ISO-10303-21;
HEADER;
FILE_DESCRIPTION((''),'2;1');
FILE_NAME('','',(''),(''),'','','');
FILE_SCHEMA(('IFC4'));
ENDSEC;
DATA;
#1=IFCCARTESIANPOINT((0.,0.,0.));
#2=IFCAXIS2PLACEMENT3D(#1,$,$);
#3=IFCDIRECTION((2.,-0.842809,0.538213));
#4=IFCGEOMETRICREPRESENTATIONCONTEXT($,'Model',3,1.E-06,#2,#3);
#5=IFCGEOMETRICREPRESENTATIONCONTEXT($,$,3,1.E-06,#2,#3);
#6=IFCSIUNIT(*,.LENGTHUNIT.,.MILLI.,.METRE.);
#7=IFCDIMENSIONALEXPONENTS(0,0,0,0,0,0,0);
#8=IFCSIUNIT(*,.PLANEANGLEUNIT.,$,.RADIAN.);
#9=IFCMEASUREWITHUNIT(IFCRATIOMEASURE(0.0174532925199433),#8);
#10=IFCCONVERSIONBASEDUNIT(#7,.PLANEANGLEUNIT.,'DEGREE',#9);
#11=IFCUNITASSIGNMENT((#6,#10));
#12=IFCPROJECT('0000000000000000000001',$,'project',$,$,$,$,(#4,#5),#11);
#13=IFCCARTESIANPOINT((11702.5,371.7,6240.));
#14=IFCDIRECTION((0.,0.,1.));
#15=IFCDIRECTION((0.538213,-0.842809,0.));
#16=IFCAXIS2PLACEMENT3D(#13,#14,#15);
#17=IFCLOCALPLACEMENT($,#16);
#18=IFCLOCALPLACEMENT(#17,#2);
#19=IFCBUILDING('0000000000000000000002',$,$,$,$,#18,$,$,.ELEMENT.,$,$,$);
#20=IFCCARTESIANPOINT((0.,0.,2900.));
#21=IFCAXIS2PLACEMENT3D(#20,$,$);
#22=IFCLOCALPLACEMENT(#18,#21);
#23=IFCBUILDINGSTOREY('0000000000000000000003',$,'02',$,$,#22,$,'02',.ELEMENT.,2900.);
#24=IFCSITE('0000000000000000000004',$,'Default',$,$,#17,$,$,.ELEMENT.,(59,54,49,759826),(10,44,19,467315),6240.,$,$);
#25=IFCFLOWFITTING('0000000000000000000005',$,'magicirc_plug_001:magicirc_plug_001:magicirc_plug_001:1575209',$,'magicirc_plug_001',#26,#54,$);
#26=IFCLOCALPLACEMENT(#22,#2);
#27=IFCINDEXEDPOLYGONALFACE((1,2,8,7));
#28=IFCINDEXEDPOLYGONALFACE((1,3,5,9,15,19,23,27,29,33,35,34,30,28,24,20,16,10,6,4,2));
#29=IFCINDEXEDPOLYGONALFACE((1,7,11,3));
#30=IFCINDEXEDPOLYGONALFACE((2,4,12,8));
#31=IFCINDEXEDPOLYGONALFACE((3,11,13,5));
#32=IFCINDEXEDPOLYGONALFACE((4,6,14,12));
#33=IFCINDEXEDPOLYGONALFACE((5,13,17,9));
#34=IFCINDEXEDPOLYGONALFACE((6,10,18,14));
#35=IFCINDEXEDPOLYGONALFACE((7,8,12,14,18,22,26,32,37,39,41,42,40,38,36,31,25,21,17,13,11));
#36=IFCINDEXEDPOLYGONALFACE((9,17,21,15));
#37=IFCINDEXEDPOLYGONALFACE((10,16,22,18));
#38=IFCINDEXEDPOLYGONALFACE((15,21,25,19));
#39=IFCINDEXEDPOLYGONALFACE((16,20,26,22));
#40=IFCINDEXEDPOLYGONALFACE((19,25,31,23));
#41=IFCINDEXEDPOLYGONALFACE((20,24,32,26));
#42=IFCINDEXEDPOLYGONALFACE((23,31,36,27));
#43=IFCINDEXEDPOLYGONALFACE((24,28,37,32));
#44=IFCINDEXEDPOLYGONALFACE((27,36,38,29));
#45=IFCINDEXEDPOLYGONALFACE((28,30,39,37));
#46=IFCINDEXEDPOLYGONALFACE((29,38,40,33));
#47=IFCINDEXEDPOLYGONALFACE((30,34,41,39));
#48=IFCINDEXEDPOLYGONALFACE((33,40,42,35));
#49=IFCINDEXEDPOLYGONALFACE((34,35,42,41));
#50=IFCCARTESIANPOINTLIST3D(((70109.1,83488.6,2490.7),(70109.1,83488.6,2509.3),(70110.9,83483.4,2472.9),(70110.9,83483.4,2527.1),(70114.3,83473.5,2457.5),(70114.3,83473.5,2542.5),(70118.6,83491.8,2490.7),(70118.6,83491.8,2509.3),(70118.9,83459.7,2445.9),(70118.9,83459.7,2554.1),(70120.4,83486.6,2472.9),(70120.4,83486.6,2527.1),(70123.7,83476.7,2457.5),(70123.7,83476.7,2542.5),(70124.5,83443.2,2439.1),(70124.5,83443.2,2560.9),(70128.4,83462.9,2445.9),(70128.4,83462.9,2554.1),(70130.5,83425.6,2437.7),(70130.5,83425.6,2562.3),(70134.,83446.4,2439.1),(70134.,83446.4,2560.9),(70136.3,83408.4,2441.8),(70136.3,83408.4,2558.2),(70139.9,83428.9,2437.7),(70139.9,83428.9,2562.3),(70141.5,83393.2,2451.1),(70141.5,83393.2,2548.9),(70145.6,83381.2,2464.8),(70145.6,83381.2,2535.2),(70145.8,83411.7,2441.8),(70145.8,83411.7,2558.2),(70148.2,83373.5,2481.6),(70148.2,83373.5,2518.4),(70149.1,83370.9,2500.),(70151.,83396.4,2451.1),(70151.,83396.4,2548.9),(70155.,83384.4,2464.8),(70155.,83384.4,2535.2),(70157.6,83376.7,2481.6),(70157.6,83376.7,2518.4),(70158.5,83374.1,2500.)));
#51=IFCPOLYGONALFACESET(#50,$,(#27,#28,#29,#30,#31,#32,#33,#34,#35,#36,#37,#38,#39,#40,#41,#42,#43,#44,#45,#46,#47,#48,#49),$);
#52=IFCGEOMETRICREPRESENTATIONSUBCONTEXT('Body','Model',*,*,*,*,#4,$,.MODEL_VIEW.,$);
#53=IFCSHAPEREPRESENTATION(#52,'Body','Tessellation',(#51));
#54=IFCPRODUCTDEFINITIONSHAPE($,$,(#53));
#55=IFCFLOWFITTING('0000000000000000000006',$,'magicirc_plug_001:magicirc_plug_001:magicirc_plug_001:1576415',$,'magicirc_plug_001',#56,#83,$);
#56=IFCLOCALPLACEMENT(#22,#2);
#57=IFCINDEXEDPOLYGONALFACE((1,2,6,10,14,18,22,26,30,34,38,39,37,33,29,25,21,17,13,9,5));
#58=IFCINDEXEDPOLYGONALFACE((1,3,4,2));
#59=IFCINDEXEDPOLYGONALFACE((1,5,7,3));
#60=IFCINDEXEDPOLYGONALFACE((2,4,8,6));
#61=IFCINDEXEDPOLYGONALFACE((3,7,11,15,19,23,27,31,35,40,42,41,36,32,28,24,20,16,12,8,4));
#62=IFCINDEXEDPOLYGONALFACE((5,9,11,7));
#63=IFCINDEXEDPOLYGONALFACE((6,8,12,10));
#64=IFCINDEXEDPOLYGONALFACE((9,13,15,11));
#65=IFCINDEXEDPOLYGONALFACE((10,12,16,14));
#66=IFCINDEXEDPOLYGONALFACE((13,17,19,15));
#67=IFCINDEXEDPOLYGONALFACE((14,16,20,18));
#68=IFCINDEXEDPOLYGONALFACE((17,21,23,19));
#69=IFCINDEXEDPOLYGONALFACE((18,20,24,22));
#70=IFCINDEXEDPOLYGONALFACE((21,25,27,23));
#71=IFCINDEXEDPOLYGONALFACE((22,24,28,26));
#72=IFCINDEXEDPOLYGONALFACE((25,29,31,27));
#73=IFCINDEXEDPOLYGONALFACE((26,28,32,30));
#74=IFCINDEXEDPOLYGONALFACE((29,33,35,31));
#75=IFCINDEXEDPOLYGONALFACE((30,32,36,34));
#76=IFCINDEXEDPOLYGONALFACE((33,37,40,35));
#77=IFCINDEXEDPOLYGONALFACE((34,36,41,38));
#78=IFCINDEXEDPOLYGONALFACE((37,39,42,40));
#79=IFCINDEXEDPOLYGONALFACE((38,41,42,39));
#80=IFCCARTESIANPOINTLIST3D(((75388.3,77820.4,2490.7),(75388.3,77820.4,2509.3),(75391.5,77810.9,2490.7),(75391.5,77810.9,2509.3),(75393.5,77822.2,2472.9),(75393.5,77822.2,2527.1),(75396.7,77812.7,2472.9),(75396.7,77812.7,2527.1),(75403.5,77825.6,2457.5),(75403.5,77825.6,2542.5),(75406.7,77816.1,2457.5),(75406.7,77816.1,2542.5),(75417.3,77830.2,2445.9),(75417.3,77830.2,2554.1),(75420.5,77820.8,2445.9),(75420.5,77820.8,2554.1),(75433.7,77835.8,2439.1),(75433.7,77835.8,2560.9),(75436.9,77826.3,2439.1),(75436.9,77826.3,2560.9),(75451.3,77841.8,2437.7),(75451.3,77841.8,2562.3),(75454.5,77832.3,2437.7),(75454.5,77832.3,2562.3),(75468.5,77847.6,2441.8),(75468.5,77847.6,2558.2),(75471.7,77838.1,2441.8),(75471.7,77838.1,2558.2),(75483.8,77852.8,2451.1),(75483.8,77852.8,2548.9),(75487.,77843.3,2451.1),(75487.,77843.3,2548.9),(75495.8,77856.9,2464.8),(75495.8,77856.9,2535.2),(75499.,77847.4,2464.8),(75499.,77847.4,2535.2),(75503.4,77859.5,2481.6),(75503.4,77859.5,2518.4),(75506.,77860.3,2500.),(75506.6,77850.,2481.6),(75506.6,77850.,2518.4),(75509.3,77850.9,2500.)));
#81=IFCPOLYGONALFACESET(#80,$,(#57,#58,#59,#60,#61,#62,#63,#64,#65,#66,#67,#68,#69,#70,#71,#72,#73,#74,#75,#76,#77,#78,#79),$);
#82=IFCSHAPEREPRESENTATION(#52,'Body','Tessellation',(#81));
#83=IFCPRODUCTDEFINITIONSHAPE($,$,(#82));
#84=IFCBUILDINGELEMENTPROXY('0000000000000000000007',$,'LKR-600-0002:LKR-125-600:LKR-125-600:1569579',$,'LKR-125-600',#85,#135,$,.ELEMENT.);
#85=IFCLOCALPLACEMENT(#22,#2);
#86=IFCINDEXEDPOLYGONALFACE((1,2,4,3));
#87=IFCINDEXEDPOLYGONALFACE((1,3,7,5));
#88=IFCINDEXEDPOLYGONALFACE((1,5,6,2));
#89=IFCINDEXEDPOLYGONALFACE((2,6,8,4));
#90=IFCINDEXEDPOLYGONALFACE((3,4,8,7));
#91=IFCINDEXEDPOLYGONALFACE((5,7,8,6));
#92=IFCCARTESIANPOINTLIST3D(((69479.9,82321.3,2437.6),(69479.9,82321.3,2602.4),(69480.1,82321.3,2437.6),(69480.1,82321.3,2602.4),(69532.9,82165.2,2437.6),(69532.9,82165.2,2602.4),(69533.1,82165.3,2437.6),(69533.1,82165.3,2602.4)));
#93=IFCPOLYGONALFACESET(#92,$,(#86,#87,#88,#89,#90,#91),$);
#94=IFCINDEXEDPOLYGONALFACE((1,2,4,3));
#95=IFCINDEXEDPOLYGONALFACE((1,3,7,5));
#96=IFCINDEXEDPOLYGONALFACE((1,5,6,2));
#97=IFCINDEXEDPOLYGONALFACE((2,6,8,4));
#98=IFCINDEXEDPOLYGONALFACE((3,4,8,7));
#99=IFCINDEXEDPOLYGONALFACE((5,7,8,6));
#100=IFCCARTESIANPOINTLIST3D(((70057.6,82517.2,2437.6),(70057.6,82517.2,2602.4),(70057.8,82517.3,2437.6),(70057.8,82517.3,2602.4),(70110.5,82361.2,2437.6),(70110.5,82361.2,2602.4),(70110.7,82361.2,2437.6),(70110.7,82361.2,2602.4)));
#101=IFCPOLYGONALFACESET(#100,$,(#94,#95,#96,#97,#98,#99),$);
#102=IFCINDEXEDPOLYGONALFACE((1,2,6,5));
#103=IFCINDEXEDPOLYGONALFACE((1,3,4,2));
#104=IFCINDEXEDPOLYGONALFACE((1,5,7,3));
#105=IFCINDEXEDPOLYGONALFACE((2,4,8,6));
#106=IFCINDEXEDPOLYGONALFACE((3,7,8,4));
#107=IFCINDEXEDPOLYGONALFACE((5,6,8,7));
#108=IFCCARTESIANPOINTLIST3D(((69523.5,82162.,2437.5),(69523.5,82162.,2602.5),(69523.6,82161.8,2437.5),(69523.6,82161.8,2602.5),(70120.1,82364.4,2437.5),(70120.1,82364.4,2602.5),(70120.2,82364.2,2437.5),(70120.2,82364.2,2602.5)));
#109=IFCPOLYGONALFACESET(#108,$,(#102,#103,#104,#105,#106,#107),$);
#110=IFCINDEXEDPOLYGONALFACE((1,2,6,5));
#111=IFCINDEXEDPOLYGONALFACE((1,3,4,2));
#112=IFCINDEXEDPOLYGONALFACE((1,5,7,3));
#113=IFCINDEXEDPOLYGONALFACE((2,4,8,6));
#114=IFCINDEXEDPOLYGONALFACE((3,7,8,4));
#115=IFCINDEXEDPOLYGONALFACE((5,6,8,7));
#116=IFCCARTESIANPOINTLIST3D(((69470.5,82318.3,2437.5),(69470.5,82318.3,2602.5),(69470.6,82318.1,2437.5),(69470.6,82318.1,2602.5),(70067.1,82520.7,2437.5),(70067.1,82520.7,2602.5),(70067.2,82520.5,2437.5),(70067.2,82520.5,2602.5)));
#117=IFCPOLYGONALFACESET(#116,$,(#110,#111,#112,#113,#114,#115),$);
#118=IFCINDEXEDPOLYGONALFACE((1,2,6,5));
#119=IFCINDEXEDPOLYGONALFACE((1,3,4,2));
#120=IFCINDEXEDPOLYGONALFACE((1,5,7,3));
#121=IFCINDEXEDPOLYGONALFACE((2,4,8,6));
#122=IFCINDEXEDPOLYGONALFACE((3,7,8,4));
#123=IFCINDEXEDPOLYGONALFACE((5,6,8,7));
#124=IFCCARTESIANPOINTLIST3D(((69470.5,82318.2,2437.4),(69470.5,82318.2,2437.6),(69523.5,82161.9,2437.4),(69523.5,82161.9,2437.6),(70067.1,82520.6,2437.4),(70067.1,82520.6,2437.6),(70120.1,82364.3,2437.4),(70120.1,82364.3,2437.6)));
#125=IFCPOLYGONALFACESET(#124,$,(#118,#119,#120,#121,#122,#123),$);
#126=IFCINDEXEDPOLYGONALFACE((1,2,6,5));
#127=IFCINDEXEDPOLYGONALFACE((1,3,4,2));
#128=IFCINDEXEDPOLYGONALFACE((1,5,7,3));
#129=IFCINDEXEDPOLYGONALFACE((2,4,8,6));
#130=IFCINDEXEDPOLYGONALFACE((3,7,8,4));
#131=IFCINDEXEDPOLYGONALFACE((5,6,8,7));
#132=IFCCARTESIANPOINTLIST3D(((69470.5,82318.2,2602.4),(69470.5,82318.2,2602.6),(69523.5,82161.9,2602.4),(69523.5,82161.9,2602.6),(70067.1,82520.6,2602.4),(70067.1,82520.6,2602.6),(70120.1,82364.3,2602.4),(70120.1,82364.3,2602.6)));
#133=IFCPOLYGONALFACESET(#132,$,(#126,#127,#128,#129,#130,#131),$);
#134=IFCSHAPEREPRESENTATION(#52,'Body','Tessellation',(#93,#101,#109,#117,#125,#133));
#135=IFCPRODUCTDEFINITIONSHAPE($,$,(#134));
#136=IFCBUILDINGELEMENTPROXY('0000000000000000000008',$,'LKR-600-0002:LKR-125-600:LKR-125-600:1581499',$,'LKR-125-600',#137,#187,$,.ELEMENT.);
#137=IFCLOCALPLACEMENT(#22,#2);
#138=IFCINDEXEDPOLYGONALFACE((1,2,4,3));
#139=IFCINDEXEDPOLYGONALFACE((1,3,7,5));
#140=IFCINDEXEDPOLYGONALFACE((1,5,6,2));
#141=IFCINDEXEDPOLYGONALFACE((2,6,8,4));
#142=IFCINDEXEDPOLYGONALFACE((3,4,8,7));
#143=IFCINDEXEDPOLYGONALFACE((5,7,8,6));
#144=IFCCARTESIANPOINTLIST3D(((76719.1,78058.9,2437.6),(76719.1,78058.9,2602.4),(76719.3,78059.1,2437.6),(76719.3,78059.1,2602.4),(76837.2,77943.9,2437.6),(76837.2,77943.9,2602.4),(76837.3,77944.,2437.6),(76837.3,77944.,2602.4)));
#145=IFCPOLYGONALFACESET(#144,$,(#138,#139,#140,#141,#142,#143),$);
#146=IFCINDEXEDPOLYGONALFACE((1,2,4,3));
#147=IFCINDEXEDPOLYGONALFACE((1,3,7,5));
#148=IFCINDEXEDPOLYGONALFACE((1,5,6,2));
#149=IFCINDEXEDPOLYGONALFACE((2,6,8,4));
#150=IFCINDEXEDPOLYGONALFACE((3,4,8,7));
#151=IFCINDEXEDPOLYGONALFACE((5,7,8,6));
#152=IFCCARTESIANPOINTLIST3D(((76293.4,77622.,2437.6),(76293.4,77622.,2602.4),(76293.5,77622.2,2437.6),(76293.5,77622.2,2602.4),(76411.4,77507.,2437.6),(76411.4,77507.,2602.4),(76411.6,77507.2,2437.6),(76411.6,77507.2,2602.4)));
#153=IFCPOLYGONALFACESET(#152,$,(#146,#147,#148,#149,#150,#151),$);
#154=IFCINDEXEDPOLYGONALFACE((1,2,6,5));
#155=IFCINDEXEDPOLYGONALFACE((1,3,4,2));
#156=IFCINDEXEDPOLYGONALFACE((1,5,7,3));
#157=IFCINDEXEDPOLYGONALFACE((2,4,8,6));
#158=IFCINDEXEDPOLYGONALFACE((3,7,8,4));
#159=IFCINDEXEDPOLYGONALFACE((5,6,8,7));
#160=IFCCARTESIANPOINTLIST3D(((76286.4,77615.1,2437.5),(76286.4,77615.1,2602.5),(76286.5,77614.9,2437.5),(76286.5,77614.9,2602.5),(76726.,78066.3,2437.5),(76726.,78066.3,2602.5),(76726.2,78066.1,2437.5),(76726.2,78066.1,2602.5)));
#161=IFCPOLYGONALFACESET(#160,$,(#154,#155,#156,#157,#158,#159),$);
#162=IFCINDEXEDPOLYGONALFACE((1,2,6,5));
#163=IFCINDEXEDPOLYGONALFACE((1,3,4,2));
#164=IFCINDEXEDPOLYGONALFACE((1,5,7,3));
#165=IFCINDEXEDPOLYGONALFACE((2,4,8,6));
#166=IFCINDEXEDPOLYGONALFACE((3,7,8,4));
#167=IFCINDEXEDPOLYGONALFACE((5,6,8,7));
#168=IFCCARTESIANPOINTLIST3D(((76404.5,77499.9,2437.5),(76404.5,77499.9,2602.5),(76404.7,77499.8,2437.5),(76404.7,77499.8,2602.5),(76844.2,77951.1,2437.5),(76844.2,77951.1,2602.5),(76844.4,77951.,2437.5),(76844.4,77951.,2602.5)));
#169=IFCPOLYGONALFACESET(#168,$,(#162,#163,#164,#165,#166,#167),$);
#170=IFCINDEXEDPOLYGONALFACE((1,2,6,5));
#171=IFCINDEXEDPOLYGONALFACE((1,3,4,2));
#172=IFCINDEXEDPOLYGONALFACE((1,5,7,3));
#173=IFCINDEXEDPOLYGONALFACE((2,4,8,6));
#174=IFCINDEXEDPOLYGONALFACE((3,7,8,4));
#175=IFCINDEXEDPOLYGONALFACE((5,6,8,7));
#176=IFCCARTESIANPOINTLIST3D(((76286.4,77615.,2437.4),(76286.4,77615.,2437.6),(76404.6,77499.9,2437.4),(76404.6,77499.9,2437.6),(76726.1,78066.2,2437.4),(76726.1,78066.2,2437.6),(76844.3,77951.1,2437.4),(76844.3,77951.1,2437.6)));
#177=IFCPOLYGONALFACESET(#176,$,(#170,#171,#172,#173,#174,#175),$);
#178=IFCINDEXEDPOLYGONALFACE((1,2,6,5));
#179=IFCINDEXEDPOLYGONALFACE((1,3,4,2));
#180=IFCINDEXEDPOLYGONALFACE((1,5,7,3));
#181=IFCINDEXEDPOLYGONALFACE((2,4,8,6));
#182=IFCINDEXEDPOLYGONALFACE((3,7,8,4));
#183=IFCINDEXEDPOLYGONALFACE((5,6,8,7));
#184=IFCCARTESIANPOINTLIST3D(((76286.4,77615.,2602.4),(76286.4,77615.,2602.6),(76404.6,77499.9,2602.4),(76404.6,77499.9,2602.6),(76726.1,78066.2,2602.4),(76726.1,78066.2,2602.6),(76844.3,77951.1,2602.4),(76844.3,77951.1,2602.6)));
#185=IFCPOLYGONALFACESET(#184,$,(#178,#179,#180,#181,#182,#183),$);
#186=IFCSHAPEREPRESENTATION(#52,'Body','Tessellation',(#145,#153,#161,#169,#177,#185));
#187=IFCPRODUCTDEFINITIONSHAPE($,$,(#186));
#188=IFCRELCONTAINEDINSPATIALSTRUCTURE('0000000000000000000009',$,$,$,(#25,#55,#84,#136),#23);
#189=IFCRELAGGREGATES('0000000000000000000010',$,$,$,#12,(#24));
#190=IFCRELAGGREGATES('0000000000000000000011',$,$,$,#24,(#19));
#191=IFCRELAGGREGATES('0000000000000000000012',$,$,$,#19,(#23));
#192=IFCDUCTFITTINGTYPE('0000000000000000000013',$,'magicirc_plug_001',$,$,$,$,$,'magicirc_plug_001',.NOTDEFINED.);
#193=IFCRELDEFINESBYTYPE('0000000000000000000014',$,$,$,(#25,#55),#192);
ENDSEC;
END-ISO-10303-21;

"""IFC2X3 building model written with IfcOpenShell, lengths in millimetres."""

from ifc_helpers import new_model, entity, si_unit, converted_unit, direction, frame, frame_2d, origin, place, context, subcontext, project, spatial, rectangle, circle, extrude, source, transform, mapped, type_object, type_shapes, element, save


model = new_model("IFC2X3")

# Units and contexts
model_context = context("Model", 3, precision=1e-06, world=origin(), true_north=direction((2.0, -0.842809, 0.538213)))
context_of_model = context(None, 3, precision=1e-06, world=origin(), true_north=direction((2.0, -0.842809, 0.538213)))
body_context = subcontext(model_context, "Body", "Model", "MODEL_VIEW")
ifc_project = project(units=[si_unit("LENGTHUNIT", "METRE", prefix="MILLI"), converted_unit("PLANEANGLEUNIT", "DEGREE", entity("IfcRatioMeasure", 0.0174532925199433), si_unit("PLANEANGLEUNIT", "RADIAN"), dimensions=[0, 0, 0, 0, 0, 0, 0])], contexts=[model_context, context_of_model])

# Site, building, storey
site_placement = place(None, frame((11702.5, 371.7, 6240.0), z_axis=(0.0, 0.0, 1.0), x_axis=(0.538213, -0.842809, 0.0)))
site = spatial("IfcSite", under=ifc_project, at=site_placement, Name="Default", CompositionType="ELEMENT", RefLatitude=(59, 54, 49, 759826), RefLongitude=(10, 44, 19, 467315), RefElevation=6240.0)
building_placement = place(site_placement, origin())
building = spatial("IfcBuilding", under=site, at=building_placement, CompositionType="ELEMENT")
storey_placement = place(building_placement, frame((0.0, 0.0, 2900.0)))
storey = spatial("IfcBuildingStorey", under=building, at=storey_placement, Name="02", LongName="02", CompositionType="ELEMENT", Elevation=2900.0)

# Flow fittings
duct_fitting_type_1 = type_object("IfcDuctFittingType", Name="magicirc_plug_001", ElementType="magicirc_plug_001", PredefinedType="NOTDEFINED")
shared_shape_1 = source(origin(), body_context, "Body", "SweptSolid", [
    extrude(circle(Radius=62.5, at=frame_2d((0.0, 0.0), x_axis=(1.0, 0.0))), frame((0.0, 0.0, 0.0), z_axis=(1.0, 0.0, 0.0), x_axis=(0.0, 1.0, 0.0)), (0.0, 0.0, 1.0), 10.0),
])
type_shapes(duct_fitting_type_1, [shared_shape_1])
for number, where, z_axis, x_axis, name in (
    (1, (70138.4, 83433.3, 2500.0), (0.0, 0.0, 1.0), (-0.946986, -0.321274, 0.0), "magicirc_plug_001:magicirc_plug_001:magicirc_plug_001:1575209"),
    (2, (75446.9, 77840.3, 2500.0), (0.0, 0.0, 1.0), (0.321274, -0.946986, 0.0), "magicirc_plug_001:magicirc_plug_001:magicirc_plug_001:1576415"),
):
    element("IfcFlowFitting", number, at=place(storey_placement, frame(where, z_axis=z_axis, x_axis=x_axis)), inside=storey, type_object=duct_fitting_type_1, Name=name, ObjectType="magicirc_plug_001", context=body_context, shape_type="MappedRepresentation", body=[
        mapped(shared_shape_1, transform((0.0, 0.0, 0.0), scale=1.0)),
    ])

# Building element proxies
shared_shape_2 = source(origin(), body_context, "Body", "SweptSolid", [
    extrude(rectangle(XDim=0.2, YDim=164.8, at=frame_2d((0.0, 0.0), x_axis=(1.0, 0.0))), frame((305.0, 0.0, -82.4)), (0.0, 0.0, 1.0), 164.8),
    extrude(rectangle(XDim=0.2, YDim=164.8, at=frame_2d((0.0, 0.0), x_axis=(1.0, 0.0))), frame((-305.0, 0.0, -82.4)), (0.0, 0.0, 1.0), 164.8),
    extrude(rectangle(XDim=0.2, YDim=630.0, at=frame_2d((0.0, 0.0), x_axis=(1.0, 0.0))), frame((0.0, 82.5, -82.5), z_axis=(0.0, 0.0, 1.0), x_axis=(0.0, 1.0, 0.0)), (0.0, 0.0, 1.0), 165.0),
    extrude(rectangle(XDim=0.2, YDim=630.0, at=frame_2d((0.0, 0.0), x_axis=(1.0, 0.0))), frame((0.0, -82.5, -82.5), z_axis=(0.0, 0.0, 1.0), x_axis=(0.0, 1.0, 0.0)), (0.0, 0.0, 1.0), 165.0),
    extrude(rectangle(XDim=165.0, YDim=630.0, at=frame_2d((0.0, 0.0), x_axis=(1.0, 0.0))), frame((0.0, 0.0, -82.6), z_axis=(0.0, 0.0, 1.0), x_axis=(0.0, -1.0, 0.0)), (0.0, 0.0, 1.0), 0.2),
    extrude(rectangle(XDim=165.0, YDim=630.0, at=frame_2d((0.0, 0.0), x_axis=(1.0, 0.0))), frame((0.0, 0.0, 82.4), z_axis=(0.0, 0.0, 1.0), x_axis=(0.0, -1.0, 0.0)), (0.0, 0.0, 1.0), 0.2),
])
for number, where, z_axis, x_axis, name in (
    (3, (69795.3, 82341.3, 2520.0), (0.0, 0.0, 1.0), (-0.946986, -0.321274, 0.0), "LKR-600-0002:LKR-125-600:LKR-125-600:1569579"),
    (4, (76565.4, 77783.0, 2520.0), (0.0, 0.0, 1.0), (0.697915, 0.71618, 0.0), "LKR-600-0002:LKR-125-600:LKR-125-600:1581499"),
):
    element("IfcBuildingElementProxy", number, at=place(storey_placement, frame(where, z_axis=z_axis, x_axis=x_axis)), inside=storey, Name=name, ObjectType="LKR-125-600", CompositionType="ELEMENT", context=body_context, shape_type="MappedRepresentation", body=[
        mapped(shared_shape_2, transform((0.0, 0.0, 0.0), scale=1.0)),
    ])

save(model, "model.ifc")
